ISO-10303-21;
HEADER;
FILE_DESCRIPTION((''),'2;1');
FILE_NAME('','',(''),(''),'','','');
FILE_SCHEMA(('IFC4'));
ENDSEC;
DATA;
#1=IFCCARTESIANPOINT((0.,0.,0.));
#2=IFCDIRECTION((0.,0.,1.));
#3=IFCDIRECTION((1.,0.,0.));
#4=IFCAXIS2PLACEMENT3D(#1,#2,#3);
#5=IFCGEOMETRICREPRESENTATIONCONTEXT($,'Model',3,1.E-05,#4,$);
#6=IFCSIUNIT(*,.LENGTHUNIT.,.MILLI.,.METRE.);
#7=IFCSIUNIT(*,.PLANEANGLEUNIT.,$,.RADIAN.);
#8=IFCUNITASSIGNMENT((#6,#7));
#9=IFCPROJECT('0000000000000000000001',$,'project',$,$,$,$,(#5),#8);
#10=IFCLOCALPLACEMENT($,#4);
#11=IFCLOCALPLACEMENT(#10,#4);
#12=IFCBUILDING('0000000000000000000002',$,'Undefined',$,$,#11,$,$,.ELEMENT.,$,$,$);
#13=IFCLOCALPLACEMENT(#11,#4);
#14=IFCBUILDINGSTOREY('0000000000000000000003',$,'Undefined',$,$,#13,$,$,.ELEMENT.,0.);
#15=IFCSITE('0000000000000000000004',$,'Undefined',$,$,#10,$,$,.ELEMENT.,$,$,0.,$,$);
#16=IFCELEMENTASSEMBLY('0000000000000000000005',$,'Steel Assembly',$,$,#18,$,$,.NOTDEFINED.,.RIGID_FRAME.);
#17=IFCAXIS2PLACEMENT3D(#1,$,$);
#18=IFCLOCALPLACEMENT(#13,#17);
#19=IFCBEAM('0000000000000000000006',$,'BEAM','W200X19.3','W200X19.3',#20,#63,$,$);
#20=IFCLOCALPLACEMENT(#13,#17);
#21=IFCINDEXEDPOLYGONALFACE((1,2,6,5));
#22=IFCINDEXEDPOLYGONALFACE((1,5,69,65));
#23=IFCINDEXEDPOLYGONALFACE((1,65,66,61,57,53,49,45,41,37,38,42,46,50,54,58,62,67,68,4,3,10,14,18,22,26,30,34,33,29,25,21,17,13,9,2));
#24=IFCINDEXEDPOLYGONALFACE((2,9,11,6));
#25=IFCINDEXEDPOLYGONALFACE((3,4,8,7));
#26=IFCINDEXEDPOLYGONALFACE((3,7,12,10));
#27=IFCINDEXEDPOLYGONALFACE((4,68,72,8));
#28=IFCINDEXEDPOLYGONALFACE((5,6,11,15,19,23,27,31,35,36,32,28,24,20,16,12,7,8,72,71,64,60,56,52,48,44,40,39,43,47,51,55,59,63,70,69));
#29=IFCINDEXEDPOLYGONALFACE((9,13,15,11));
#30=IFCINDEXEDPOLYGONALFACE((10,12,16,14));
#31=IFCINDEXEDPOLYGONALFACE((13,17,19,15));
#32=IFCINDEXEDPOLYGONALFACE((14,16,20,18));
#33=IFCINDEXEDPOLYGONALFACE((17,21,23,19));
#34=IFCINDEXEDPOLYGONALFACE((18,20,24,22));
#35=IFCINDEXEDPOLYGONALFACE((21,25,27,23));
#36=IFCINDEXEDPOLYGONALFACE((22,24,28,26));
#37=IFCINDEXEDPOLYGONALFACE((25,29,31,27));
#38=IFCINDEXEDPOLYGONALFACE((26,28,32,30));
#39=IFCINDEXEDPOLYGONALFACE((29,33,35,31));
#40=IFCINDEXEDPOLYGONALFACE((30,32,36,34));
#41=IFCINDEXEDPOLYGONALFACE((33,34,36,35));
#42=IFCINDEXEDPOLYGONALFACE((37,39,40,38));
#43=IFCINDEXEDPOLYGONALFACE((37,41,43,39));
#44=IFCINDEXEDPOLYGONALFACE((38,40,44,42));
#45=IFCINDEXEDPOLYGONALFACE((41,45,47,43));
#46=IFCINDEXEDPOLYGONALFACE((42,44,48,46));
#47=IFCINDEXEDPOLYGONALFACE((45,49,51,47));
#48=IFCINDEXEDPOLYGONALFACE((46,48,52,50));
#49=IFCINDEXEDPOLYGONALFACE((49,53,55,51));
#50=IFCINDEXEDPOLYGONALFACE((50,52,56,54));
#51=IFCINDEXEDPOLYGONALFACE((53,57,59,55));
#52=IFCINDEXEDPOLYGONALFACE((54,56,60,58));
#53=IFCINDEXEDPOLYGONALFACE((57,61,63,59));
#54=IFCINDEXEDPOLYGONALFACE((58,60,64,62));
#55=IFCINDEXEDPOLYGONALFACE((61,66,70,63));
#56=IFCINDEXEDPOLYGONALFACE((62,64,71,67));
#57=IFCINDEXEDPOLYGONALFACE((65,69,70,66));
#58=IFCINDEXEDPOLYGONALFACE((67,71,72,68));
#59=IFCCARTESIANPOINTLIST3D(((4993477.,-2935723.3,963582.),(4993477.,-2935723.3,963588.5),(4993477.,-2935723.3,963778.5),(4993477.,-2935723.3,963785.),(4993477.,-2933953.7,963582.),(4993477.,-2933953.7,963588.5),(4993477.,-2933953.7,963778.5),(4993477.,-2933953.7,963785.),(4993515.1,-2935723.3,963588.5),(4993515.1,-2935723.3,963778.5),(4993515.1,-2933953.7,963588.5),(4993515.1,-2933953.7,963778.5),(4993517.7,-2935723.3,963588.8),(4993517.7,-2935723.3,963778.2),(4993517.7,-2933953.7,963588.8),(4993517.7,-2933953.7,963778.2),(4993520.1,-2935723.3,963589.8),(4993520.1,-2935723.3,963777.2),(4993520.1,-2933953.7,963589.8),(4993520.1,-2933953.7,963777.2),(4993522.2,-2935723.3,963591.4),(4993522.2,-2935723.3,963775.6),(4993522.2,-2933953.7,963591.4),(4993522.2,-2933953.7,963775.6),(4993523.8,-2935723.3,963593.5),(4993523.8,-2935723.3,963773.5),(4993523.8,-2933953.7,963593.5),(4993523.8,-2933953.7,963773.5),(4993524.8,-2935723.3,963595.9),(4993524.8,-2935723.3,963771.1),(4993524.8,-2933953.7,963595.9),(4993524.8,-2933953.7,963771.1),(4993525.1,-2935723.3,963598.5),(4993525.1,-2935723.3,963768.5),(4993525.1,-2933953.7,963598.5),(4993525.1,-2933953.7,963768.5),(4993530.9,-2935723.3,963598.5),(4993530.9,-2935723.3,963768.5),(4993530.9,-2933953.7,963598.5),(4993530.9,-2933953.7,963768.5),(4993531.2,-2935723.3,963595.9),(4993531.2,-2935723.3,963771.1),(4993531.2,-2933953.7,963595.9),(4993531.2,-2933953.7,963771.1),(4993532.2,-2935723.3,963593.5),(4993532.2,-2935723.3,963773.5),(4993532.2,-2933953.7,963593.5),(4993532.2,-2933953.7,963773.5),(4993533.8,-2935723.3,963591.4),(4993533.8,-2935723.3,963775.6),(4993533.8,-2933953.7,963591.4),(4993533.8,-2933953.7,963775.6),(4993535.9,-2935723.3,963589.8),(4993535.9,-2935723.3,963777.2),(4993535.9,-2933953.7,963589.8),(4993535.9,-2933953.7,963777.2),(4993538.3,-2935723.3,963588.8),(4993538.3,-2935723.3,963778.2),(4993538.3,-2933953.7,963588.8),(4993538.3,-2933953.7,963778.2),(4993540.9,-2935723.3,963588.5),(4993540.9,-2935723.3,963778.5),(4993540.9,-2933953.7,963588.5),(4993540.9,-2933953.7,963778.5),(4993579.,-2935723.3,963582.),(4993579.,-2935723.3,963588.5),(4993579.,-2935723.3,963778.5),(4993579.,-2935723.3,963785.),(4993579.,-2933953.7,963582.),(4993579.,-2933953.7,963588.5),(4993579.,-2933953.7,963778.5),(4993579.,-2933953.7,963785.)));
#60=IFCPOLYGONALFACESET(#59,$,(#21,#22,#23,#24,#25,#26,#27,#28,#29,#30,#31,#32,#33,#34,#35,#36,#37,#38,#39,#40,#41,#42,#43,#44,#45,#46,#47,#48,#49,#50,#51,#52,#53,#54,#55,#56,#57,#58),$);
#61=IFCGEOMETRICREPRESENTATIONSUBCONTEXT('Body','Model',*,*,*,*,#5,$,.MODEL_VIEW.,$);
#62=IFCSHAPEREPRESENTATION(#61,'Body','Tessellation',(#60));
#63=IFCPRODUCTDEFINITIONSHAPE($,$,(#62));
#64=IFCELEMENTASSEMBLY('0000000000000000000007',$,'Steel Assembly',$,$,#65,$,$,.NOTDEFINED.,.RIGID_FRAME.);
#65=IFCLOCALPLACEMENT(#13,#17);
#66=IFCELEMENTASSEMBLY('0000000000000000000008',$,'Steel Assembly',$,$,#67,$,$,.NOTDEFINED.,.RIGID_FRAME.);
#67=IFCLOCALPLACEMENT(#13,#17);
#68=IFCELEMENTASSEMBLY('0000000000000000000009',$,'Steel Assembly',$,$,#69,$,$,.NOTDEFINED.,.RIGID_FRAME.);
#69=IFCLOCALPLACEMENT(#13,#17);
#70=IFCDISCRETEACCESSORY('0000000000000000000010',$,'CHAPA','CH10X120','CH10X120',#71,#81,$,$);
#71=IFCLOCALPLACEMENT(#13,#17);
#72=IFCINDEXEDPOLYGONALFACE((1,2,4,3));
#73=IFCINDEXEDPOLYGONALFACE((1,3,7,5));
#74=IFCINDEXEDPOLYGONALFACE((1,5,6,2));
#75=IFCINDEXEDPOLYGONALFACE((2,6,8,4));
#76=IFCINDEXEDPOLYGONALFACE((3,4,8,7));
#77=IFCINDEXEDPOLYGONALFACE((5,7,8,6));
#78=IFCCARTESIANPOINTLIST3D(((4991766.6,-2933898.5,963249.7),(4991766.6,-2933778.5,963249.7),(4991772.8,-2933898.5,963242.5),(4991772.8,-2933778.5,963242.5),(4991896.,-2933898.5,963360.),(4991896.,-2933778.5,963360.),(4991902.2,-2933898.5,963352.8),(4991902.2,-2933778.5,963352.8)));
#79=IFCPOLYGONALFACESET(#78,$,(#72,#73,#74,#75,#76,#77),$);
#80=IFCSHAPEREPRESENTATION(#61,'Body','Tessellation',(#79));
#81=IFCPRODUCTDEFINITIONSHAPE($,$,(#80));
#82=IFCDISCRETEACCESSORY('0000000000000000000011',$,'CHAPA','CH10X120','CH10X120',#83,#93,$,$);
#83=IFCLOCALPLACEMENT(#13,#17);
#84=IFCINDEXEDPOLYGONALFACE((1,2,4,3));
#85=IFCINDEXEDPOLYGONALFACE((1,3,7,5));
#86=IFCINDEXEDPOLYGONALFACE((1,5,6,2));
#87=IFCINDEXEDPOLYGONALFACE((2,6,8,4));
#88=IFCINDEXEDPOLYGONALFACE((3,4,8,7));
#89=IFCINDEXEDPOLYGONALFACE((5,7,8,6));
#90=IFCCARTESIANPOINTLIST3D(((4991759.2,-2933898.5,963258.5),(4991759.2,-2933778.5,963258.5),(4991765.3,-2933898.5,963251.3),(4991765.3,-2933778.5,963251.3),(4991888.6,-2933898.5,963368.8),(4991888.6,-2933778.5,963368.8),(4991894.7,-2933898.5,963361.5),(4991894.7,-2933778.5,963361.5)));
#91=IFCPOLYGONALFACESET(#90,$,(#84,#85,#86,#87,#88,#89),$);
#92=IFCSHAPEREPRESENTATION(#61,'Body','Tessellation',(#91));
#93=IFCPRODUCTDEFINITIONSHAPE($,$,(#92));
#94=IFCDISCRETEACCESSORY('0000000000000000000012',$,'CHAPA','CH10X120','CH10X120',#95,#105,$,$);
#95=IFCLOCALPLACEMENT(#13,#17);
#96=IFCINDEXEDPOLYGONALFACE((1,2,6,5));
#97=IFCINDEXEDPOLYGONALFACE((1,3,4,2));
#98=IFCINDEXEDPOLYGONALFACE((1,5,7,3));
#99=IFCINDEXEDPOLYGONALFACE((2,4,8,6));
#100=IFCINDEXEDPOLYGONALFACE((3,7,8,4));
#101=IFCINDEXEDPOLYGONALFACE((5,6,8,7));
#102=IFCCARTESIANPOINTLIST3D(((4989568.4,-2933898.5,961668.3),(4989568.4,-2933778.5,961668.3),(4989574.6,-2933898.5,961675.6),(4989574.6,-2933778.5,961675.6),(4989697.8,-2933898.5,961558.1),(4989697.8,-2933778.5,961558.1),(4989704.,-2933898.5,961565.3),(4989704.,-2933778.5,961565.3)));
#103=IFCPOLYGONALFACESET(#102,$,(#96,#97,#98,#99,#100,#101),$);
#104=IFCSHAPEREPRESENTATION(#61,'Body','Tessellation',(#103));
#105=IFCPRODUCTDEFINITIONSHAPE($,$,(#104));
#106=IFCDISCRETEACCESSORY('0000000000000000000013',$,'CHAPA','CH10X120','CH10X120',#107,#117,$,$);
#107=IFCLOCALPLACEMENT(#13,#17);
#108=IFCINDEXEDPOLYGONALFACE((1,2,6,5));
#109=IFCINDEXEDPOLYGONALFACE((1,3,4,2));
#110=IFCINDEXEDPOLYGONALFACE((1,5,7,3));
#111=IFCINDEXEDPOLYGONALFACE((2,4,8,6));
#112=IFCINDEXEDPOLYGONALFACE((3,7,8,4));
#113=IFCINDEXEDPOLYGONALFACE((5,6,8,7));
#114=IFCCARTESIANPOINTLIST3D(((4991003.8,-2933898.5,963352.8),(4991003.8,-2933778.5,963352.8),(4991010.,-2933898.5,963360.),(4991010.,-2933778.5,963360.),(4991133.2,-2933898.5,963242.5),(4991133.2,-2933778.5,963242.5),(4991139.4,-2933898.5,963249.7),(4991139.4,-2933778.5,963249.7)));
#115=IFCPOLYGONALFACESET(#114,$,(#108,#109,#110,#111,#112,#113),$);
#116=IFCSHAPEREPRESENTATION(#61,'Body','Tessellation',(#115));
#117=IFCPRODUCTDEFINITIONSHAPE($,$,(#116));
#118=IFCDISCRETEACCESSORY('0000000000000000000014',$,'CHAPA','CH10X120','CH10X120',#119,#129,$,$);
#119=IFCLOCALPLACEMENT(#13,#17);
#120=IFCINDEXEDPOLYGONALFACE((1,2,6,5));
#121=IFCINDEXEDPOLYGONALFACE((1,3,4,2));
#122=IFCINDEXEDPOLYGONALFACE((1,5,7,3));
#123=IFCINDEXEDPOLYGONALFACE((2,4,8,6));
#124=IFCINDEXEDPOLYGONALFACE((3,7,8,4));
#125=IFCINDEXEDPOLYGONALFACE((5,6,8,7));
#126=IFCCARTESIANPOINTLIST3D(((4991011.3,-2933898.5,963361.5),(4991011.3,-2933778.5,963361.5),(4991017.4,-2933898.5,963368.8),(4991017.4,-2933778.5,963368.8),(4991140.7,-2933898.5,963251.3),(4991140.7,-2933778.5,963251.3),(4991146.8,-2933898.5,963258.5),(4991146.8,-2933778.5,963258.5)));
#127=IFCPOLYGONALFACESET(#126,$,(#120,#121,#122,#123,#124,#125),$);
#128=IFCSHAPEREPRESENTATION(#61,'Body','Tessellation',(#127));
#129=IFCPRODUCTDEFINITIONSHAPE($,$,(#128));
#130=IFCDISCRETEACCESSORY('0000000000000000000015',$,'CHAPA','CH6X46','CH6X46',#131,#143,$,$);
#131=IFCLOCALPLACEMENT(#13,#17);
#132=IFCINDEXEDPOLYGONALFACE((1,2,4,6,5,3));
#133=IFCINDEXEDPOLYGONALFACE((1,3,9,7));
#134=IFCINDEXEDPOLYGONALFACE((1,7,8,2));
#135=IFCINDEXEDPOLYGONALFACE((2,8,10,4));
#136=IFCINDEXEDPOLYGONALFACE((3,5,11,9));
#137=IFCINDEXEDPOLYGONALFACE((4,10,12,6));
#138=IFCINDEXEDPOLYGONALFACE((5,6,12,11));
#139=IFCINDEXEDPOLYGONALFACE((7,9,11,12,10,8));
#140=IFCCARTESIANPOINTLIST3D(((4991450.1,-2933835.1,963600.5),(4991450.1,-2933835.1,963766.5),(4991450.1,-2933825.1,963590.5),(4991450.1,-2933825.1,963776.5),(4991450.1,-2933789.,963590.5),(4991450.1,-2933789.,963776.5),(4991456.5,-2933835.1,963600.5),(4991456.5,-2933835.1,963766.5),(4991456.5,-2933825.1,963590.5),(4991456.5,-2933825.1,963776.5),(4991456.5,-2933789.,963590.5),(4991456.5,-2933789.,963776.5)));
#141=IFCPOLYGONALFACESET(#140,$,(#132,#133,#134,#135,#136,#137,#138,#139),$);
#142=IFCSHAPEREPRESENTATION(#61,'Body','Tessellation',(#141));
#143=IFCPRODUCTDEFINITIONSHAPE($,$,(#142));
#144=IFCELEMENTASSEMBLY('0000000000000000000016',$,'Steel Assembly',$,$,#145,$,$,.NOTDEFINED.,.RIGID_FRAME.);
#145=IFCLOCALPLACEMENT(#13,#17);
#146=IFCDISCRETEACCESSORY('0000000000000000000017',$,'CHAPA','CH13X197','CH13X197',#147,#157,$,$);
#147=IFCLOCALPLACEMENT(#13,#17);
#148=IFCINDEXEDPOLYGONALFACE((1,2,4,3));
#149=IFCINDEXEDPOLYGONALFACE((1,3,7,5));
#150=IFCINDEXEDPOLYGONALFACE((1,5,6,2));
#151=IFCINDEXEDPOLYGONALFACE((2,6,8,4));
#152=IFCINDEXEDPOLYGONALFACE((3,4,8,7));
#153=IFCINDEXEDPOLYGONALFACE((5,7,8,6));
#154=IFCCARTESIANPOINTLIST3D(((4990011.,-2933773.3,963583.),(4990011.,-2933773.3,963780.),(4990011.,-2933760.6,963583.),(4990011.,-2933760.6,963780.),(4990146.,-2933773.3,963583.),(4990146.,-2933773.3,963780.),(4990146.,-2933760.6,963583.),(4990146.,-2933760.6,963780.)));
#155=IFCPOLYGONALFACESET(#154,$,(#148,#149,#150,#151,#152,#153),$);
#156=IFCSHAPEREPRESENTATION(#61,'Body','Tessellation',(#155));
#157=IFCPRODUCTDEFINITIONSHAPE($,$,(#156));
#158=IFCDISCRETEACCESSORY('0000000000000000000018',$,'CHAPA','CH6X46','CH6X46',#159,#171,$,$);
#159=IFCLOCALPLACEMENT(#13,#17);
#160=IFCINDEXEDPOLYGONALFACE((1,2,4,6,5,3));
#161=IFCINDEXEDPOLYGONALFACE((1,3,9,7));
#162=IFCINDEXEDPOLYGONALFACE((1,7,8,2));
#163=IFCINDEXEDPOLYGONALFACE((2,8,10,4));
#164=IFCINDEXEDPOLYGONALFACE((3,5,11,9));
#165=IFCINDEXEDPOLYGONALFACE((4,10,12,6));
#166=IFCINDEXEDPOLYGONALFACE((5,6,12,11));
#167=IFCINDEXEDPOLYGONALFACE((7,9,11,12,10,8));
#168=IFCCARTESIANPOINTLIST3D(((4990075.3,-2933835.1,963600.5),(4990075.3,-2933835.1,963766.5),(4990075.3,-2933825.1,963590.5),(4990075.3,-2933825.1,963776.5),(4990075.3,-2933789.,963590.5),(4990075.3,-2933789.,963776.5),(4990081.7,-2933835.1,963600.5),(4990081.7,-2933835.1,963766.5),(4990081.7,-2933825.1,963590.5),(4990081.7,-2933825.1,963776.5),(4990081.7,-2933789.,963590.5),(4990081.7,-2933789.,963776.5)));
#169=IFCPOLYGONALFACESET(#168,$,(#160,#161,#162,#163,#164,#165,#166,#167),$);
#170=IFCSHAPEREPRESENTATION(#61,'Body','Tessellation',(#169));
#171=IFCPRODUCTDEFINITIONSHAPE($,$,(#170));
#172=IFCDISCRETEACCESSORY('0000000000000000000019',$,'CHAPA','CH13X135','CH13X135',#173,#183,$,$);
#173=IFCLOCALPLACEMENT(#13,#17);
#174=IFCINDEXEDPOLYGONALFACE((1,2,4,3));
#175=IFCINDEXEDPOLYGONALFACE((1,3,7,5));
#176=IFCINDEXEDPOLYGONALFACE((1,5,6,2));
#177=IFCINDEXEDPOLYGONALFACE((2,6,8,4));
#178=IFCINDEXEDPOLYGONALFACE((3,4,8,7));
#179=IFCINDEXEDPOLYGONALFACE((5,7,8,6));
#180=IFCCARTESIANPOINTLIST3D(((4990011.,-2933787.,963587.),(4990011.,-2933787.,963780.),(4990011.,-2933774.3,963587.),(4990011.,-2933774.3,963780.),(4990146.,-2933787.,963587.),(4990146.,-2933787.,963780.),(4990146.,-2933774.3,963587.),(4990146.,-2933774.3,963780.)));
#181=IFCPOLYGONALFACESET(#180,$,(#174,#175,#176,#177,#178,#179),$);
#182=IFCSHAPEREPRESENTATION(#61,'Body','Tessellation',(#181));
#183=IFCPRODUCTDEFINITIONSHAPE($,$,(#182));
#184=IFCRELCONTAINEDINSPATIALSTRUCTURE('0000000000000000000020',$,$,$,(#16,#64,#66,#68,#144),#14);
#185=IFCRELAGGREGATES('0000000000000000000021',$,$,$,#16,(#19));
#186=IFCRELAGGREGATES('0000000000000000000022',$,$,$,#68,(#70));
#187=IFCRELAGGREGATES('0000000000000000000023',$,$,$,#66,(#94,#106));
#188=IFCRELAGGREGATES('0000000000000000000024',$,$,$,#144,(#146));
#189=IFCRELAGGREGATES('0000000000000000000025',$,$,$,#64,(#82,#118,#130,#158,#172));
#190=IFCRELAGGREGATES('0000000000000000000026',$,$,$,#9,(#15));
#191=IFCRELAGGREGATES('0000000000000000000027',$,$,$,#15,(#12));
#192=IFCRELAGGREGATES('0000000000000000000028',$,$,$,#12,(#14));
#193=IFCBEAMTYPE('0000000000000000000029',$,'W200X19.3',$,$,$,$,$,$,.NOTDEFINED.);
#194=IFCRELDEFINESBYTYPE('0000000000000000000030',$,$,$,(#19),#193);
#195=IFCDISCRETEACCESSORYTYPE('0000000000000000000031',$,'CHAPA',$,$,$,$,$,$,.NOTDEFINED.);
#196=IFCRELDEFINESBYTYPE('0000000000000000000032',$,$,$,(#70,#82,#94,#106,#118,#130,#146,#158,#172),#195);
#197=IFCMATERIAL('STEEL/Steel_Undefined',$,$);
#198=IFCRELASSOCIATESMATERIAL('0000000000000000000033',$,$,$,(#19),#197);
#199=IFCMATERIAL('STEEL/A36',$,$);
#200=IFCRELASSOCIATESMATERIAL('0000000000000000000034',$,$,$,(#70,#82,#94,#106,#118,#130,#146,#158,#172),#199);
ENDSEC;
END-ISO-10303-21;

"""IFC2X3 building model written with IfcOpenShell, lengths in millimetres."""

from ifc_helpers import new_model, si_unit, frame, origin_with_axes, origin_2d_with_axis, place, context, subcontext, project, spatial, polyline, rectangle, i_section, outline, extrude, clip, halfspace, material, type_object, element, aggregate, save


model = new_model("IFC2X3")

# Units and contexts
model_context = context("Model", 3, precision=1e-05, world=origin_with_axes())
body_context = subcontext(model_context, "Body", "Model", "MODEL_VIEW")
ifc_project = project(units=[si_unit("LENGTHUNIT", "METRE", prefix="MILLI"), si_unit("PLANEANGLEUNIT", "RADIAN")], contexts=[model_context])

# Site, building, storey
site_placement = place(None, origin_with_axes())
site = spatial("IfcSite", under=ifc_project, at=site_placement, Name="Undefined", CompositionType="ELEMENT", RefElevation=0.0)
building_placement = place(site_placement, origin_with_axes())
building = spatial("IfcBuilding", under=site, at=building_placement, Name="Undefined", CompositionType="ELEMENT")
storey_placement = place(building_placement, origin_with_axes())
storey = spatial("IfcBuildingStorey", under=building, at=storey_placement, Name="Undefined", CompositionType="ELEMENT", Elevation=0.0)

# Element assemblies, beam
assembly_1_placement = place(storey_placement, origin_with_axes())
assembly_1 = element("IfcElementAssembly", 1, at=assembly_1_placement, inside=storey, Name="Steel Assembly", AssemblyPlace="NOTDEFINED", PredefinedType="RIGID_FRAME")
ifc_material_1 = material(Name="STEEL/Steel_Undefined")
beam_type_1 = type_object("IfcBeamType", Name="W200X19.3", PredefinedType="NOTDEFINED")
beam_1_placement = place(assembly_1_placement, frame((4993528.0, -2933838.5, 963683.5), z_axis=(0.0, 0.0, -1.0), x_axis=(0.0, -1.0, 0.0)))
beam_1 = element("IfcBeam", 2, at=beam_1_placement, type_object=beam_type_1, material=ifc_material_1, Name="BEAM", Description="W200X19.3", ObjectType="W200X19.3", context=body_context, shape_type="Clipping", body=[
    clip(clip(clip(clip(extrude(i_section(OverallWidth=102.0, OverallDepth=203.0, WebThickness=5.8, FlangeThickness=6.5, FilletRadius=10.0, at=origin_2d_with_axis()), frame((1884.8, 0.0, 0.0), z_axis=(-1.0, 0.0, 0.0), x_axis=(0.0, -1.0, 0.0)), (0.0, 0.0, 1.0), 1769.6), halfspace(frame((112.5, -51.0, 101.5), z_axis=(-1.0, 0.0, 0.0), x_axis=(0.0, 0.0, -1.0)), False)), halfspace(frame((1887.5, 51.0, 101.5), z_axis=(1.0, 0.0, 0.0), x_axis=(0.0, 0.0, -1.0)), False)), halfspace(frame((1884.8, 0.0, 101.5), z_axis=(-1.0, 0.0, 0.0), x_axis=(0.0, -1.0, 0.0)), True)), halfspace(frame((115.2, 0.0, 101.5), z_axis=(1.0, 0.0, 0.0), x_axis=(0.0, 1.0, 0.0)), True)),
])
aggregate(assembly_1, [beam_1])
assembly_2_placement = place(storey_placement, origin_with_axes())
assembly_2 = element("IfcElementAssembly", 3, at=assembly_2_placement, inside=storey, Name="Steel Assembly", AssemblyPlace="NOTDEFINED", PredefinedType="RIGID_FRAME")

# Element assembly
assembly_3_placement = place(storey_placement, origin_with_axes())
assembly_3 = element("IfcElementAssembly", 4, at=assembly_3_placement, inside=storey, Name="Steel Assembly", AssemblyPlace="NOTDEFINED", PredefinedType="RIGID_FRAME")

# Element assembly, discrete accessory
assembly_4_placement = place(storey_placement, origin_with_axes())
assembly_4 = element("IfcElementAssembly", 5, at=assembly_4_placement, inside=storey, Name="Steel Assembly", AssemblyPlace="NOTDEFINED", PredefinedType="RIGID_FRAME")
ifc_material_2 = material(Name="STEEL/A36")
discrete_accessory_type_1 = type_object("IfcDiscreteAccessoryType", Name="CHAPA")
discrete_accessory_1_placement = place(assembly_4_placement, frame((4991899.1, -2933838.5, 963356.4), z_axis=(0.0, 1.0, 0.0), x_axis=(-0.761138, 0.0, -0.64859)))
discrete_accessory_1 = element("IfcDiscreteAccessory", 6, at=discrete_accessory_1_placement, type_object=discrete_accessory_type_1, material=ifc_material_2, Name="CHAPA", Description="CH10X120", ObjectType="CH10X120", context=body_context, shape_type="SweptSolid", body=[
    extrude(rectangle(XDim=9.5, YDim=120.0, at=origin_2d_with_axis()), frame((170.0, 0.0, 0.0), z_axis=(-1.0, 0.0, 0.0), x_axis=(0.0, -1.0, 0.0)), (0.0, 0.0, 1.0), 170.0),
])
aggregate(assembly_4, [discrete_accessory_1])

# Discrete accessories
discrete_accessory_2_placement = place(assembly_2_placement, frame((4991891.7, -2933838.5, 963365.1), z_axis=(0.0, 1.0, 0.0), x_axis=(-0.761138, 0.0, -0.64859)))
discrete_accessory_2 = element("IfcDiscreteAccessory", 7, at=discrete_accessory_2_placement, type_object=discrete_accessory_type_1, material=ifc_material_2, Name="CHAPA", Description="CH10X120", ObjectType="CH10X120", context=body_context, shape_type="SweptSolid", body=[
    extrude(rectangle(XDim=9.5, YDim=120.0, at=origin_2d_with_axis()), frame((170.0, 0.0, 0.0), z_axis=(-1.0, 0.0, 0.0), x_axis=(0.0, -1.0, 0.0)), (0.0, 0.0, 1.0), 170.0),
])
discrete_accessory_3_placement = place(assembly_3_placement, frame((4989571.5, -2933838.5, 961671.9), z_axis=(0.0, 1.0, 0.0), x_axis=(0.761138, 0.0, -0.64859)))
discrete_accessory_3 = element("IfcDiscreteAccessory", 8, at=discrete_accessory_3_placement, type_object=discrete_accessory_type_1, material=ifc_material_2, Name="CHAPA", Description="CH10X120", ObjectType="CH10X120", context=body_context, shape_type="SweptSolid", body=[
    extrude(rectangle(XDim=9.5, YDim=120.0, at=origin_2d_with_axis()), frame((170.0, 0.0, 0.0), z_axis=(-1.0, 0.0, 0.0), x_axis=(0.0, -1.0, 0.0)), (0.0, 0.0, 1.0), 170.0),
])
discrete_accessory_4_placement = place(assembly_3_placement, frame((4991006.9, -2933838.5, 963356.4), z_axis=(0.0, -1.0, 0.0), x_axis=(0.761138, 0.0, -0.64859)))
discrete_accessory_4 = element("IfcDiscreteAccessory", 9, at=discrete_accessory_4_placement, type_object=discrete_accessory_type_1, material=ifc_material_2, Name="CHAPA", Description="CH10X120", ObjectType="CH10X120", context=body_context, shape_type="SweptSolid", body=[
    extrude(rectangle(XDim=9.5, YDim=120.0, at=origin_2d_with_axis()), frame((170.0, 0.0, 0.0), z_axis=(-1.0, 0.0, 0.0), x_axis=(0.0, -1.0, 0.0)), (0.0, 0.0, 1.0), 170.0),
])
aggregate(assembly_3, [discrete_accessory_3, discrete_accessory_4])
discrete_accessory_5_placement = place(assembly_2_placement, frame((4991014.3, -2933838.5, 963365.1), z_axis=(0.0, -1.0, 0.0), x_axis=(0.761138, 0.0, -0.64859)))
discrete_accessory_5 = element("IfcDiscreteAccessory", 10, at=discrete_accessory_5_placement, type_object=discrete_accessory_type_1, material=ifc_material_2, Name="CHAPA", Description="CH10X120", ObjectType="CH10X120", context=body_context, shape_type="SweptSolid", body=[
    extrude(rectangle(XDim=9.5, YDim=120.0, at=origin_2d_with_axis()), frame((170.0, 0.0, 0.0), z_axis=(-1.0, 0.0, 0.0), x_axis=(0.0, -1.0, 0.0)), (0.0, 0.0, 1.0), 170.0),
])
discrete_accessory_6_placement = place(assembly_2_placement, frame((4991453.3, -2933835.1, 963776.5), z_axis=(-1.0, 0.0, 0.0), x_axis=(0.0, 1.0, 0.0)))
discrete_accessory_6 = element("IfcDiscreteAccessory", 11, at=discrete_accessory_6_placement, type_object=discrete_accessory_type_1, material=ifc_material_2, Name="CHAPA", Description="CH6X46", ObjectType="CH6X46", context=body_context, shape_type="SweptSolid", body=[
    extrude(outline(polyline([(0.0, 10.0), (10.0, 0.0), (46.1, 0.0), (46.1, 186.0), (10.0, 186.0), (0.0, 176.0), (0.0, 10.0)])), frame((0.0, 0.0, -3.2), z_axis=(0.0, 0.0, 1.0), x_axis=(1.0, 0.0, 0.0)), (0.0, 0.0, 1.0), 6.4),
])

# Element assembly, discrete accessory
assembly_5_placement = place(storey_placement, origin_with_axes())
assembly_5 = element("IfcElementAssembly", 12, at=assembly_5_placement, inside=storey, Name="Steel Assembly", AssemblyPlace="NOTDEFINED", PredefinedType="RIGID_FRAME")
discrete_accessory_7_placement = place(assembly_5_placement, frame((4990078.5, -2933767.0, 963780.0), z_axis=(0.0, 1.0, 0.0), x_axis=(0.0, 0.0, -1.0)))
discrete_accessory_7 = element("IfcDiscreteAccessory", 13, at=discrete_accessory_7_placement, type_object=discrete_accessory_type_1, material=ifc_material_2, Name="CHAPA", Description="CH13X197", ObjectType="CH13X197", context=body_context, shape_type="SweptSolid", body=[
    extrude(outline(polyline([(197.0, 67.5), (197.0, -67.5), (0.0, -67.5), (0.0, 67.5), (197.0, 67.5)])), frame((0.0, 0.0, -6.3), z_axis=(0.0, 0.0, 1.0), x_axis=(1.0, 0.0, 0.0)), (0.0, 0.0, 1.0), 12.7),
])
aggregate(assembly_5, [discrete_accessory_7])

# Discrete accessories
discrete_accessory_8_placement = place(assembly_2_placement, frame((4990078.5, -2933835.1, 963776.5), z_axis=(-1.0, 0.0, 0.0), x_axis=(0.0, 1.0, 0.0)))
discrete_accessory_8 = element("IfcDiscreteAccessory", 14, at=discrete_accessory_8_placement, type_object=discrete_accessory_type_1, material=ifc_material_2, Name="CHAPA", Description="CH6X46", ObjectType="CH6X46", context=body_context, shape_type="SweptSolid", body=[
    extrude(outline(polyline([(0.0, 10.0), (10.0, 0.0), (46.1, 0.0), (46.1, 186.0), (10.0, 186.0), (0.0, 176.0), (0.0, 10.0)])), frame((0.0, 0.0, -3.2), z_axis=(0.0, 0.0, 1.0), x_axis=(1.0, 0.0, 0.0)), (0.0, 0.0, 1.0), 6.4),
])
discrete_accessory_9_placement = place(assembly_2_placement, frame((4990078.5, -2933780.7, 963780.0), z_axis=(0.0, 1.0, 0.0), x_axis=(0.0, 0.0, -1.0)))
discrete_accessory_9 = element("IfcDiscreteAccessory", 15, at=discrete_accessory_9_placement, type_object=discrete_accessory_type_1, material=ifc_material_2, Name="CHAPA", Description="CH13X135", ObjectType="CH13X135", context=body_context, shape_type="SweptSolid", body=[
    extrude(outline(polyline([(193.0, 67.5), (193.0, -67.5), (0.0, -67.5), (0.0, 67.5), (193.0, 67.5)])), frame((0.0, 0.0, -6.3), z_axis=(0.0, 0.0, 1.0), x_axis=(1.0, 0.0, 0.0)), (0.0, 0.0, 1.0), 12.7),
])

aggregate(assembly_2, [discrete_accessory_2, discrete_accessory_5, discrete_accessory_6, discrete_accessory_8, discrete_accessory_9])

save(model, "model.ifc")
